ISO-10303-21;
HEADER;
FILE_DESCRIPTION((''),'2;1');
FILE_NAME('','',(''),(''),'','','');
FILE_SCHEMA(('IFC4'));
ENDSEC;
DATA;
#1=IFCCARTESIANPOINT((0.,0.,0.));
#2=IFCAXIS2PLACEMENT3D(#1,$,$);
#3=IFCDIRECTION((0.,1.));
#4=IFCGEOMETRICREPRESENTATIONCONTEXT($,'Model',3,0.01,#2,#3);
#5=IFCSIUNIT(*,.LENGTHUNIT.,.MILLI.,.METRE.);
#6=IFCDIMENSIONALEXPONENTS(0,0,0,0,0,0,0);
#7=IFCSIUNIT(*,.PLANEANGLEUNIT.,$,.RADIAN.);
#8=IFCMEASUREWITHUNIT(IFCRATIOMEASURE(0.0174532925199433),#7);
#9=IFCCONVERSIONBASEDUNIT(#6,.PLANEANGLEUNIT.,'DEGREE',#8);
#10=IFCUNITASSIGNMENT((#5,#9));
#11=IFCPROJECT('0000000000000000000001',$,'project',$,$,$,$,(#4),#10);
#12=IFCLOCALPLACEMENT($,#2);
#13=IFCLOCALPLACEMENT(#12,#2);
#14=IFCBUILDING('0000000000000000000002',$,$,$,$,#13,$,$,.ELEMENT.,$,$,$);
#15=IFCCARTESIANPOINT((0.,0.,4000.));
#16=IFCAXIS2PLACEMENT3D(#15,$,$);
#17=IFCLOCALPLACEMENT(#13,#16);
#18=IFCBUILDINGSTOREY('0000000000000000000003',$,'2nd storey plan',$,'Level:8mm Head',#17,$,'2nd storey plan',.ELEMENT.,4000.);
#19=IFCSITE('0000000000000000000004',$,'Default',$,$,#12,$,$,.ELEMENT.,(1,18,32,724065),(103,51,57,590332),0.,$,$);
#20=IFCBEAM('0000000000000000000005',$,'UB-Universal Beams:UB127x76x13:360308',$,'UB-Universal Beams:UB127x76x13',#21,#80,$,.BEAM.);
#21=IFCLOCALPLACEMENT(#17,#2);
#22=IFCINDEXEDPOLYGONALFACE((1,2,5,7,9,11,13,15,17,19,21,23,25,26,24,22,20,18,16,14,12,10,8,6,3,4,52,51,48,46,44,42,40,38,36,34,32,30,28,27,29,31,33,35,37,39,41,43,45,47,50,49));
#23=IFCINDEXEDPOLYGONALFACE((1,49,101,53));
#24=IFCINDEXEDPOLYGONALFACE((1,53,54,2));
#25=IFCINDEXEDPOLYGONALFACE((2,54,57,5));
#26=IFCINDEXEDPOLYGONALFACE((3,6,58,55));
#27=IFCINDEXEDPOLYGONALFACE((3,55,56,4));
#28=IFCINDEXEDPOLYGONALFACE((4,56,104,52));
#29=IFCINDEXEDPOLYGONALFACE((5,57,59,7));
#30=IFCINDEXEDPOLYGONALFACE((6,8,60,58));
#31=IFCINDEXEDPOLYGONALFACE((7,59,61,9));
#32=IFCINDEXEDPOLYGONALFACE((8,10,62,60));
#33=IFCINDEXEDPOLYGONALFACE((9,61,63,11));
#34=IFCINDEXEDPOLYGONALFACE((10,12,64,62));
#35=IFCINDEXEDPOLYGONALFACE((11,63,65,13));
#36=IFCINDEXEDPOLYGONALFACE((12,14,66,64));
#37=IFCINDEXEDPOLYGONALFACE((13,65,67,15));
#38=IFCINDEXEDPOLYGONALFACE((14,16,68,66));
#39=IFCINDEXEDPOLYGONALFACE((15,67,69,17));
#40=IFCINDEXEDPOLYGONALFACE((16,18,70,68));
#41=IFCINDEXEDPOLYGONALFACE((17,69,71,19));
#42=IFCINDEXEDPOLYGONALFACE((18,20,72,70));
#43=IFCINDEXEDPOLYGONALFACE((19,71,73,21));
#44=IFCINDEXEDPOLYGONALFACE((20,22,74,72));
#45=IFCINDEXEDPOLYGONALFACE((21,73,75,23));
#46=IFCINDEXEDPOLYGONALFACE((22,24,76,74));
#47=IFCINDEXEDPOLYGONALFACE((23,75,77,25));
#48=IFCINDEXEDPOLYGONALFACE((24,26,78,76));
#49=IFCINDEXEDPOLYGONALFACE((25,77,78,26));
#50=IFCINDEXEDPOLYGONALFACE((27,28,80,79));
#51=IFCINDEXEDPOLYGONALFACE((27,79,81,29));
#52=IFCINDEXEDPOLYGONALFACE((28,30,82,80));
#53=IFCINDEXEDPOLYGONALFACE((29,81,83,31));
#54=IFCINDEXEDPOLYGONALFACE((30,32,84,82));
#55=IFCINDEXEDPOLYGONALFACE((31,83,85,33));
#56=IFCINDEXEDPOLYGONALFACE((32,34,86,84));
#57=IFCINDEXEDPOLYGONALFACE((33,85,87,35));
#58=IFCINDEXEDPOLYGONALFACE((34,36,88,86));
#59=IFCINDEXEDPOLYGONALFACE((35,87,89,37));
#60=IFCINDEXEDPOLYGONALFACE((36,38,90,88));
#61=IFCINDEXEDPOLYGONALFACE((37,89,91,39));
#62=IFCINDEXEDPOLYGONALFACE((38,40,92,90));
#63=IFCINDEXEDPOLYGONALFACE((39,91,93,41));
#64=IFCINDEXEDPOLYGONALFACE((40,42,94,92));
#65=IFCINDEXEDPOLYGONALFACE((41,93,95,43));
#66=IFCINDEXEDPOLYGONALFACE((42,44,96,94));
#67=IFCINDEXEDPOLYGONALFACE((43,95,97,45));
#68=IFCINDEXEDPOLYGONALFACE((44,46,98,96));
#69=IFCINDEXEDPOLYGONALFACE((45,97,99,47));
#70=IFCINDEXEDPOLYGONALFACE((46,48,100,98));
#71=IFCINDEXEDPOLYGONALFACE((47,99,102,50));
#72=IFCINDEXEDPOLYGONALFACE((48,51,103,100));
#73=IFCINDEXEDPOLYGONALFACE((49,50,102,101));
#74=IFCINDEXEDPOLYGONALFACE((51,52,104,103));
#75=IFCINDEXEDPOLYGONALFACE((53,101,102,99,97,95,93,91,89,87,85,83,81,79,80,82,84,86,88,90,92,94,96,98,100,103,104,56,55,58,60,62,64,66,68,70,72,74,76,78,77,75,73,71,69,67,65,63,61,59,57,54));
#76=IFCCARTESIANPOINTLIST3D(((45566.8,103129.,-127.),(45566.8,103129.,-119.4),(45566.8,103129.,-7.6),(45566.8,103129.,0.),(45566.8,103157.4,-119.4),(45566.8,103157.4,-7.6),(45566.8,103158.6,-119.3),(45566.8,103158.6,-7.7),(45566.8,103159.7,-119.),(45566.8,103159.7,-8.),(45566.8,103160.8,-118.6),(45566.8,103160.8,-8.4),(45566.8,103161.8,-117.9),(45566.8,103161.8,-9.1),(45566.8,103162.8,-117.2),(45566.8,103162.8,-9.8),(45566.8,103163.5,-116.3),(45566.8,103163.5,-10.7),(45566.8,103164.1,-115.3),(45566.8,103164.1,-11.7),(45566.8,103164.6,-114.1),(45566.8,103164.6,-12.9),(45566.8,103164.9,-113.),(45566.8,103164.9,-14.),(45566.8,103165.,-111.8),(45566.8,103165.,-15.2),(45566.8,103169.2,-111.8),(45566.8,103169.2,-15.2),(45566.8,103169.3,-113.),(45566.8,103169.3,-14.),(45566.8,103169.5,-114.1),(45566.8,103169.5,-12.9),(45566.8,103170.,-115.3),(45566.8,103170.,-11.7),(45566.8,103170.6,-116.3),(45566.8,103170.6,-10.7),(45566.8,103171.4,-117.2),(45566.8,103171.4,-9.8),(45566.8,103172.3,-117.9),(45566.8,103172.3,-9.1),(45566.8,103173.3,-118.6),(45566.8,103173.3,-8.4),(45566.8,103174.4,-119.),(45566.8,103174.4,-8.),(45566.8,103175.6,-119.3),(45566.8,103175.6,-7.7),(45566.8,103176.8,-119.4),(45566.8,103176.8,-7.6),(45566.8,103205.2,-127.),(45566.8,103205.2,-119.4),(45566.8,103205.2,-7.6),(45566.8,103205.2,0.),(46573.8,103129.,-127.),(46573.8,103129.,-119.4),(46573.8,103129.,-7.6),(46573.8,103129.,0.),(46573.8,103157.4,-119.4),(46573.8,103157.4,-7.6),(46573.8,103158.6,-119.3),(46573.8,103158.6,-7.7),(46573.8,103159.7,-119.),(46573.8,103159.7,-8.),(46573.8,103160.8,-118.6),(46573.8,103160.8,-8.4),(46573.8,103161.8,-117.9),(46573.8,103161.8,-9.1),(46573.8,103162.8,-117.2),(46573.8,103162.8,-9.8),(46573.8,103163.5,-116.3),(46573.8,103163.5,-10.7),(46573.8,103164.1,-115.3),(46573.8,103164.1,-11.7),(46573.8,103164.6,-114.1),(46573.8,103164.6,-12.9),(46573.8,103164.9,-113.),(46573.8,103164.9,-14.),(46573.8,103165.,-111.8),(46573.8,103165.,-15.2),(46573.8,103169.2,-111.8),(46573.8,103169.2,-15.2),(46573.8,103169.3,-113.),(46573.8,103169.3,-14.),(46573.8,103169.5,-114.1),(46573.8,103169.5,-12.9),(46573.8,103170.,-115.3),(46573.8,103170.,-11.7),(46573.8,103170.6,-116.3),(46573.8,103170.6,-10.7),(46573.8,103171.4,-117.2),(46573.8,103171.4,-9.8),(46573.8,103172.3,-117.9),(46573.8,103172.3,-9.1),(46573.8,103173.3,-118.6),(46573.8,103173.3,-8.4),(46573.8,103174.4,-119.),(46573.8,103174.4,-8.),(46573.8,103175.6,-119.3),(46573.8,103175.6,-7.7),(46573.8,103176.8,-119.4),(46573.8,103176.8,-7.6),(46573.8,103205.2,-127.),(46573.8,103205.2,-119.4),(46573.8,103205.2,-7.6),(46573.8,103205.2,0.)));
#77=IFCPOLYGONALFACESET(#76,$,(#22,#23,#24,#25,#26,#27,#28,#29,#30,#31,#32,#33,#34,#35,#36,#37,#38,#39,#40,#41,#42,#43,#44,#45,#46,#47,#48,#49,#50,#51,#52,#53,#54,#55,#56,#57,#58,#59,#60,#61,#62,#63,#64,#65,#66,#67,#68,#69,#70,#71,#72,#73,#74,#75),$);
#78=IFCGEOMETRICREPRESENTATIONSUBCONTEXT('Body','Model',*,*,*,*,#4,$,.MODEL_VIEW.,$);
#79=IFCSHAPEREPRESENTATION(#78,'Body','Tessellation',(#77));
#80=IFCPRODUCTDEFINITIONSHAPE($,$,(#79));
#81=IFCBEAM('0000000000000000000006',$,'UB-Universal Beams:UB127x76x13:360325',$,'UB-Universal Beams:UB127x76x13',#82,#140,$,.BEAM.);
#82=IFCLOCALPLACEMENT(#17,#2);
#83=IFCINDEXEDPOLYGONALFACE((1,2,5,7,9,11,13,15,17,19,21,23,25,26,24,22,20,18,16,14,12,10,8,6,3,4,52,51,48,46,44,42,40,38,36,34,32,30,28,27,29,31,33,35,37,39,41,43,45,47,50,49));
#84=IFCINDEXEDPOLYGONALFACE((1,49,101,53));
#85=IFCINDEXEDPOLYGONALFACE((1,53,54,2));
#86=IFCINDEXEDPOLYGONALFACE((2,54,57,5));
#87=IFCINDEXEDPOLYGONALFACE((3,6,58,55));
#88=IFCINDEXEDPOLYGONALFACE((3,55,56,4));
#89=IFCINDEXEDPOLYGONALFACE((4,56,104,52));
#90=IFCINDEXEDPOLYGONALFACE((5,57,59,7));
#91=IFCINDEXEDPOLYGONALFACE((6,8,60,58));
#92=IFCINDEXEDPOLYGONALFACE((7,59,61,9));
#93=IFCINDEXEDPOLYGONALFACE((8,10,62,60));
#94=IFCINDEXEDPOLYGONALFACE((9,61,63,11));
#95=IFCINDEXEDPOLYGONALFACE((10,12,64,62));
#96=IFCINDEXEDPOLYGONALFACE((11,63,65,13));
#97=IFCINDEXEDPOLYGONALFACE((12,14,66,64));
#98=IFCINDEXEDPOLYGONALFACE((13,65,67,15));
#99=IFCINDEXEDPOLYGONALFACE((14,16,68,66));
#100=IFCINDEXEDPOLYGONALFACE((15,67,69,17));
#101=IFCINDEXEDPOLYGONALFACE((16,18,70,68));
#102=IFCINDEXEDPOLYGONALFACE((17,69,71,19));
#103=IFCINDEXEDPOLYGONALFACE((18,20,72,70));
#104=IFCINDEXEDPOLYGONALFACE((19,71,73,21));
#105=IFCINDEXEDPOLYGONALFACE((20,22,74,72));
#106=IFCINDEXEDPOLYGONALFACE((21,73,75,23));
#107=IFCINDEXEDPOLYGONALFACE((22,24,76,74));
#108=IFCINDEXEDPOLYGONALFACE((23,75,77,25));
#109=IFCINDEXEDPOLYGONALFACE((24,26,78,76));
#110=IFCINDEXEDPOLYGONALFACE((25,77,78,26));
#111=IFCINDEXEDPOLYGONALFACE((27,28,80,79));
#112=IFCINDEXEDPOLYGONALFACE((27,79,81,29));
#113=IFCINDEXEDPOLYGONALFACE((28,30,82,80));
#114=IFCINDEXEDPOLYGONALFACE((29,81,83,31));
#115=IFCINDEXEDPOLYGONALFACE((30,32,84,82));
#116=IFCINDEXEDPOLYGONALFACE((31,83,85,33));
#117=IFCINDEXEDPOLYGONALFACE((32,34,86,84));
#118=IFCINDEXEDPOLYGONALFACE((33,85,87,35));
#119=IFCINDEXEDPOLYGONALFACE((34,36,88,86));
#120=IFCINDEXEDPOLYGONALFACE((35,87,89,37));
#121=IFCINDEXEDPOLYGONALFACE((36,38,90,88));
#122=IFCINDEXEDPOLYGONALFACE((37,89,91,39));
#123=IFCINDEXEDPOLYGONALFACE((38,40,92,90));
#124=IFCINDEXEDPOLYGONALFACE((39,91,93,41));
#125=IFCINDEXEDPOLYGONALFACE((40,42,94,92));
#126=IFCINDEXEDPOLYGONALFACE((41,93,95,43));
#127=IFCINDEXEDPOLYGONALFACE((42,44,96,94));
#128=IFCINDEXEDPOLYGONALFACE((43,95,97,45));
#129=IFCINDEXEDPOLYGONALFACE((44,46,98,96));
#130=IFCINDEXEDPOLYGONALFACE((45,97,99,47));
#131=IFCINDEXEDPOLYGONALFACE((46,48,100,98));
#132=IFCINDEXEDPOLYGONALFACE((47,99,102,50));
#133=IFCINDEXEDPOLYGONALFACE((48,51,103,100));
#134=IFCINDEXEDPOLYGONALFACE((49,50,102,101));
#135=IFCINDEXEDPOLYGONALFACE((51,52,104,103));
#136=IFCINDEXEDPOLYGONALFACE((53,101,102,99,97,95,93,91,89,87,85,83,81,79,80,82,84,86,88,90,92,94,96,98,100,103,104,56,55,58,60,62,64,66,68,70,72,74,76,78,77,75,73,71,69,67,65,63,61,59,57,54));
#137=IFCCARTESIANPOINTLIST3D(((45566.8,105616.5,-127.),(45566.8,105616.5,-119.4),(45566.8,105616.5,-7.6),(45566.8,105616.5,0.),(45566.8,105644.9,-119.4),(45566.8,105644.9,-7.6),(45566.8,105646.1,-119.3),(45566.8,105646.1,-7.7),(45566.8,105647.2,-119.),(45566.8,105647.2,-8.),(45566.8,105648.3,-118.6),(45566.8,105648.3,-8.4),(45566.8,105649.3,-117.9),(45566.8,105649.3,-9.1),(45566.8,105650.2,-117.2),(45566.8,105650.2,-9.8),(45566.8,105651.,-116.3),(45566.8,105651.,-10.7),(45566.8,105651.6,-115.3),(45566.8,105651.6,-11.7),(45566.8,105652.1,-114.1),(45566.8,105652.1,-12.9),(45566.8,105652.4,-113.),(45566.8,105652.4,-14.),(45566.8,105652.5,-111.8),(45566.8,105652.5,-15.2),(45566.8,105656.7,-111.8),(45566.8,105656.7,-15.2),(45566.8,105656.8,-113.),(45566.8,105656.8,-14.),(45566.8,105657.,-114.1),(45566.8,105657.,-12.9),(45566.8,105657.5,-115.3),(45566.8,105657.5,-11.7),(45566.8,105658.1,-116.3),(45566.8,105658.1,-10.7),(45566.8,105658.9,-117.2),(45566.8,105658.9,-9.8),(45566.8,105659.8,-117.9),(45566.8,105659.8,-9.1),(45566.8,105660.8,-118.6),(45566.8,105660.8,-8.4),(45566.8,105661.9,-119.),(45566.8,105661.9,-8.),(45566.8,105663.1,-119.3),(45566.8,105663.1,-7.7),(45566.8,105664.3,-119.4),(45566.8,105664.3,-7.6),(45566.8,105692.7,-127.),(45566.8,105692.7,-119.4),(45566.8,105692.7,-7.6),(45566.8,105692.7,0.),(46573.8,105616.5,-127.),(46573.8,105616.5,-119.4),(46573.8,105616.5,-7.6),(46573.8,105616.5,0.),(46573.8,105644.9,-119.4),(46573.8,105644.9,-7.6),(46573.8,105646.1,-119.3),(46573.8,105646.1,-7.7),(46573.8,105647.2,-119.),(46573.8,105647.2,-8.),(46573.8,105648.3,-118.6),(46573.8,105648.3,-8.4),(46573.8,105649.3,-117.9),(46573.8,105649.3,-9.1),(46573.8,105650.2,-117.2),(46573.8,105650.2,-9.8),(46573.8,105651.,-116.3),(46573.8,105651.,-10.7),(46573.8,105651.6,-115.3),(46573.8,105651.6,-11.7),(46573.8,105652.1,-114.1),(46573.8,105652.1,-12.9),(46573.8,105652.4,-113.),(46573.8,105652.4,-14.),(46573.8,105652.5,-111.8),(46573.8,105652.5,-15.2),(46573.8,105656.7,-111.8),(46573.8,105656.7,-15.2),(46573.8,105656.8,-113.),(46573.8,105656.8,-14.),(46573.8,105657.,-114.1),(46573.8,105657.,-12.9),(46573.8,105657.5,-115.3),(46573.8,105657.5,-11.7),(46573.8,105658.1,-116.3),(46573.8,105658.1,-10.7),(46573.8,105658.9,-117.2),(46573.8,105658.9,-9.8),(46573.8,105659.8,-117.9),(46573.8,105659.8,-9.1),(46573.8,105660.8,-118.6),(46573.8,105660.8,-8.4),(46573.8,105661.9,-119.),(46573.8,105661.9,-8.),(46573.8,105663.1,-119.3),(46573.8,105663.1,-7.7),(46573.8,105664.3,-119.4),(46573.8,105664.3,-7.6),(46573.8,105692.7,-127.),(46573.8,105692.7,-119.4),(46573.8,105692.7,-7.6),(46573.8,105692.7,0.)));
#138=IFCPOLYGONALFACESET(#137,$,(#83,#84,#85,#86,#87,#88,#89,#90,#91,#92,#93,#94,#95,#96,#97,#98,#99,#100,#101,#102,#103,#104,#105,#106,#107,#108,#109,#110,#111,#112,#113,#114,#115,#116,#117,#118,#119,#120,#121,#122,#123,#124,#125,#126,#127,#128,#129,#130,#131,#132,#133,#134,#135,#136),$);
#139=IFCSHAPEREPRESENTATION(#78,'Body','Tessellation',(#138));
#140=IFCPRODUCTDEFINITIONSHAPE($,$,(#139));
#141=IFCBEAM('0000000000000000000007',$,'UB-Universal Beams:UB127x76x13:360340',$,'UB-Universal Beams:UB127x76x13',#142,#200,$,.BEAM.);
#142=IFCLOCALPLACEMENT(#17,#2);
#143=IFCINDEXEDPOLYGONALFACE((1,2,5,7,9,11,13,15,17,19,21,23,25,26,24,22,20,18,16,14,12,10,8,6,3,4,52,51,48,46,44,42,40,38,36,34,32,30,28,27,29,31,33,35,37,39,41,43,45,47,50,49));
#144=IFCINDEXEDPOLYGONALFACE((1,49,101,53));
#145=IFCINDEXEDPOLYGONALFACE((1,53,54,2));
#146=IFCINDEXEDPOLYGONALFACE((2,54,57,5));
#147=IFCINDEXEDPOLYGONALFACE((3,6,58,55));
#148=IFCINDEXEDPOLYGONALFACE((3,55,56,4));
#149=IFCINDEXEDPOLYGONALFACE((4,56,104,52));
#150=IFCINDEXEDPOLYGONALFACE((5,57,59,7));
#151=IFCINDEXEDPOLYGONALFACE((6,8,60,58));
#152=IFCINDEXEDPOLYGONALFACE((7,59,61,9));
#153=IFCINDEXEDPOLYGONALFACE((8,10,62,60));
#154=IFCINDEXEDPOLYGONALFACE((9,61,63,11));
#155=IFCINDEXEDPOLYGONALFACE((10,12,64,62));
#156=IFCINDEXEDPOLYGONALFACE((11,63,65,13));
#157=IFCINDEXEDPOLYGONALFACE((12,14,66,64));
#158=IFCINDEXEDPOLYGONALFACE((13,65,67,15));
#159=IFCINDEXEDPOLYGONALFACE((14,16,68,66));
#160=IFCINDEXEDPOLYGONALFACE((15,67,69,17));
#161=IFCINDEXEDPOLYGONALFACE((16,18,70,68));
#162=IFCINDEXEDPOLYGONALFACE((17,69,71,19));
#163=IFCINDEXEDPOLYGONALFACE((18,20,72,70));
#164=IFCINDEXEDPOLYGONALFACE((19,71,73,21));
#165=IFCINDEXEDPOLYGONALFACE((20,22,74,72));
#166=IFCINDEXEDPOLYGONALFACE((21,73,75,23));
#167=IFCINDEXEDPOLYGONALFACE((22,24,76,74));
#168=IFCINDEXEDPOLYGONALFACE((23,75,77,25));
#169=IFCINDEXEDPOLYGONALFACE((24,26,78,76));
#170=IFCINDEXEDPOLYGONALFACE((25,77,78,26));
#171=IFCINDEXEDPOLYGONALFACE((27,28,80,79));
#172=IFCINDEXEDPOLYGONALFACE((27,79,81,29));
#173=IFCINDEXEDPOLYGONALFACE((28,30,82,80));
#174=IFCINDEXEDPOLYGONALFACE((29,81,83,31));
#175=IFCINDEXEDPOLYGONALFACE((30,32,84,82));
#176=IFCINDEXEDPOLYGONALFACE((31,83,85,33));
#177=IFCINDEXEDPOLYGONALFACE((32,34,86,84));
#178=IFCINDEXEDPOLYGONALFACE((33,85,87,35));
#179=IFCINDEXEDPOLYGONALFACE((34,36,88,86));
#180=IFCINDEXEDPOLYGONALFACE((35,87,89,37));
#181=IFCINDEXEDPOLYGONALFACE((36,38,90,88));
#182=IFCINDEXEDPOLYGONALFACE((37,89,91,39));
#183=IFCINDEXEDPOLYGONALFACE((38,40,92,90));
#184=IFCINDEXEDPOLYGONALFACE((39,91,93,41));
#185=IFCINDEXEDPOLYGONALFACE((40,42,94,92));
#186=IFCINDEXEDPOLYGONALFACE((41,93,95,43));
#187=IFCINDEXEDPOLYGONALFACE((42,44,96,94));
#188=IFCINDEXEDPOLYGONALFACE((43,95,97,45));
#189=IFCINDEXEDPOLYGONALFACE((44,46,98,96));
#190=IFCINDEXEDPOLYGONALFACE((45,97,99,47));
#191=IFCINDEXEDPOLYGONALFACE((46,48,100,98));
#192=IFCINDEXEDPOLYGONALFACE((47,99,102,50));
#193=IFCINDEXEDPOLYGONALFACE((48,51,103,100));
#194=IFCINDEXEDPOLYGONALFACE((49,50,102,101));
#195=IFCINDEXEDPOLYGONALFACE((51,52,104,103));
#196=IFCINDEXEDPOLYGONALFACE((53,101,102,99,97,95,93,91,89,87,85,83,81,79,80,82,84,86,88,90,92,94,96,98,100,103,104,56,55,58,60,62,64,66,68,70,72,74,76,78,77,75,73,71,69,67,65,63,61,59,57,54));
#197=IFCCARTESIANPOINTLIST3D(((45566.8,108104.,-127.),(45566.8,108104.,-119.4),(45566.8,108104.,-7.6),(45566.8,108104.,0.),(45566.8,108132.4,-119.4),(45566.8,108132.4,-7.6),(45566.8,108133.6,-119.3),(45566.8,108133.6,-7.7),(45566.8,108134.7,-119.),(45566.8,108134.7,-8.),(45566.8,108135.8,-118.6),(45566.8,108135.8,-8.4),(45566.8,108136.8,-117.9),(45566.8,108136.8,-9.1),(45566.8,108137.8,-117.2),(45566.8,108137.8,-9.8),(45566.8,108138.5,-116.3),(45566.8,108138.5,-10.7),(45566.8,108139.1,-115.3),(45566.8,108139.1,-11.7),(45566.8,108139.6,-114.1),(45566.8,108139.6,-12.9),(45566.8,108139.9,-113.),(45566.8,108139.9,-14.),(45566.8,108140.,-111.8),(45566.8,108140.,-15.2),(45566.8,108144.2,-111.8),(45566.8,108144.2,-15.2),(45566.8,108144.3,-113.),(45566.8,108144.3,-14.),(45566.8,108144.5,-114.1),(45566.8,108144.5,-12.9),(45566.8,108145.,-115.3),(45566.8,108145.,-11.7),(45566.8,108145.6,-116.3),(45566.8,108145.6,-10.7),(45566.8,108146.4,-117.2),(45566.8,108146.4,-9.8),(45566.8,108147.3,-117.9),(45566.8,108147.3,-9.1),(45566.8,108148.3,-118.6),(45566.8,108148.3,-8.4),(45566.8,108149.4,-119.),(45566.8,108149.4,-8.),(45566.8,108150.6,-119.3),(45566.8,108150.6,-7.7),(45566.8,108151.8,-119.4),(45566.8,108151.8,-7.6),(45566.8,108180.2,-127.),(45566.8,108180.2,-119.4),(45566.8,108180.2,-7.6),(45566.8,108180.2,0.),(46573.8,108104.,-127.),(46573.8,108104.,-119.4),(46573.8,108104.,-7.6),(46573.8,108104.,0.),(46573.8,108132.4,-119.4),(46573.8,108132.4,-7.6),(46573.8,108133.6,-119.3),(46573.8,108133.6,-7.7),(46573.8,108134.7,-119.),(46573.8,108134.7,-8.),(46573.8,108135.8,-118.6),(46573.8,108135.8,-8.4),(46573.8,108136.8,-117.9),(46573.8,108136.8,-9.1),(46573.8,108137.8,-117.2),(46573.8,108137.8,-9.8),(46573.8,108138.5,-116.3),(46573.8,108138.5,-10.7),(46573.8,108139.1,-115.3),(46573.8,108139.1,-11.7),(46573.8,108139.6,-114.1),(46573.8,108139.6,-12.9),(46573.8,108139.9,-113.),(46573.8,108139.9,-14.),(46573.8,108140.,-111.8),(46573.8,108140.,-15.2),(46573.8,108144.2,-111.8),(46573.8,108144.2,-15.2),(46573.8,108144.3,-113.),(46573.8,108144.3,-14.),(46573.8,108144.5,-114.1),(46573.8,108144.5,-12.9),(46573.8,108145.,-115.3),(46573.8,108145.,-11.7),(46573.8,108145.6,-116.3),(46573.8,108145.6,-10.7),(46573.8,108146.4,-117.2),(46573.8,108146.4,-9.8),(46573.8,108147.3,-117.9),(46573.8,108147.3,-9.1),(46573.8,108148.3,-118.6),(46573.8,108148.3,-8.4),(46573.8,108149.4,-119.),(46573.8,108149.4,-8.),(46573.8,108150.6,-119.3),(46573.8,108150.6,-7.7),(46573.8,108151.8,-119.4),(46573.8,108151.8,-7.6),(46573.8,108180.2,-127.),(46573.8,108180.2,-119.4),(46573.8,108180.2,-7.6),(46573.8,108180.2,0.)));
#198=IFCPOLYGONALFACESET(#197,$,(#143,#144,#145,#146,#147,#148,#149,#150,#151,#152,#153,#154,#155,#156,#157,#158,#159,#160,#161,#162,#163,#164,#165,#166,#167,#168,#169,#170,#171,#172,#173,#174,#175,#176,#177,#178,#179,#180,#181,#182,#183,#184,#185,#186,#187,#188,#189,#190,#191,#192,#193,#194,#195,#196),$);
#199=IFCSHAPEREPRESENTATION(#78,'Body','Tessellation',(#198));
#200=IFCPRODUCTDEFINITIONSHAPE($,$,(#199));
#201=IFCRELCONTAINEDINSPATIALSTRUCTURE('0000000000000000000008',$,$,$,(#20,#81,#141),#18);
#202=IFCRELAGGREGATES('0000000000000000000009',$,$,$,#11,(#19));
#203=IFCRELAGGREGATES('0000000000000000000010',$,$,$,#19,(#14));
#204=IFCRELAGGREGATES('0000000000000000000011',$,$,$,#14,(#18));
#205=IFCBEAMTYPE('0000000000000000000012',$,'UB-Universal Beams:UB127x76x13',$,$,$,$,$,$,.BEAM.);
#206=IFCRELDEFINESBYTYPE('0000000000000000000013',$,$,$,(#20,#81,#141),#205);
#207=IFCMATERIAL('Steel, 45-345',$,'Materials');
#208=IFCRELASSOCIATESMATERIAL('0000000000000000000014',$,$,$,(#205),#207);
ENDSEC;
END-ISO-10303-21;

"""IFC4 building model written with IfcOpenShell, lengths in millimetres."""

from ifc_helpers import new_model, entity, si_unit, converted_unit, direction, frame, origin, place, context, subcontext, project, spatial, indexed_curve, outline, extrude, source, transform, mapped, material, type_object, type_shapes, element, save


model = new_model("IFC4")

# Units and contexts
model_context = context("Model", 3, precision=0.01, world=origin(), true_north=direction((0.0, 1.0)))
body_context = subcontext(model_context, "Body", "Model", "MODEL_VIEW")
ifc_project = project(units=[si_unit("LENGTHUNIT", "METRE", prefix="MILLI"), converted_unit("PLANEANGLEUNIT", "DEGREE", entity("IfcRatioMeasure", 0.0174532925199433), si_unit("PLANEANGLEUNIT", "RADIAN"), dimensions=[0, 0, 0, 0, 0, 0, 0])], contexts=[model_context])

# Site, building, storey
site_placement = place(None, origin())
site = spatial("IfcSite", under=ifc_project, at=site_placement, Name="Default", CompositionType="ELEMENT", RefLatitude=(1, 18, 32, 724065), RefLongitude=(103, 51, 57, 590332), RefElevation=0.0)
building_placement = place(site_placement, origin())
building = spatial("IfcBuilding", under=site, at=building_placement, CompositionType="ELEMENT")
storey_placement = place(building_placement, frame((0.0, 0.0, 4000.0)))
storey = spatial("IfcBuildingStorey", under=building, at=storey_placement, Name="2nd storey plan", ObjectType="Level:8mm Head", LongName="2nd storey plan", CompositionType="ELEMENT", Elevation=4000.0)

# Beams
ifc_material_1 = material(Name="Steel, 45-345", Category="Materials")
beam_type_1 = type_object("IfcBeamType", Name="UB-Universal Beams:UB127x76x13", PredefinedType="BEAM", material=ifc_material_1)
shared_shape_1 = source(origin(), body_context, "Body", "SweptSolid", [
    extrude(outline(indexed_curve([(-63.5, -38.1), (-55.9, -38.1), (-55.9, -9.7), (-55.8, -8.5), (-55.5, -7.4), (-55.1, -6.2), (-54.4, -5.2), (-53.7, -4.3), (-52.8, -3.6), (-51.8, -2.9), (-50.6, -2.5), (-49.5, -2.2), (-48.3, -2.1), (48.3, -2.1), (49.5, -2.2), (50.6, -2.5), (51.8, -2.9), (52.8, -3.6), (53.7, -4.3), (54.4, -5.2), (55.1, -6.2), (55.5, -7.4), (55.8, -8.5), (55.9, -9.7), (55.9, -38.1), (63.5, -38.1), (63.5, 38.1), (55.9, 38.1), (55.9, 9.7), (55.8, 8.5), (55.5, 7.4), (55.1, 6.2), (54.4, 5.2), (53.7, 4.3), (52.8, 3.6), (51.8, 2.9), (50.6, 2.5), (49.5, 2.2), (48.3, 2.1), (-48.3, 2.1), (-49.5, 2.2), (-50.6, 2.5), (-51.8, 2.9), (-52.8, 3.6), (-53.7, 4.3), (-54.4, 5.2), (-55.1, 6.2), (-55.5, 7.4), (-55.8, 8.5), (-55.9, 9.7), (-55.9, 38.1), (-63.5, 38.1), (-63.5, -38.1)], self_intersect=False)), frame((-570.0, 0.0, 0.0), z_axis=(1.0, 0.0, 0.0), x_axis=(0.0, 0.0, -1.0)), (0.0, 0.0, 1.0), 1007.0),
])
type_shapes(beam_type_1, [shared_shape_1])
for number, where, name in (
    (1, (46136.8, 103167.1, -63.5), "UB-Universal Beams:UB127x76x13:360308"),
    (2, (46136.8, 105654.6, -63.5), "UB-Universal Beams:UB127x76x13:360325"),
    (3, (46136.8, 108142.1, -63.5), "UB-Universal Beams:UB127x76x13:360340"),
):
    element("IfcBeam", number, at=place(storey_placement, frame(where)), inside=storey, type_object=beam_type_1, Name=name, ObjectType="UB-Universal Beams:UB127x76x13", PredefinedType="BEAM", context=body_context, shape_type="MappedRepresentation", body=[
        mapped(shared_shape_1, transform((0.0, 0.0, 0.0), scale=1.0)),
    ])

save(model, "model.ifc")
